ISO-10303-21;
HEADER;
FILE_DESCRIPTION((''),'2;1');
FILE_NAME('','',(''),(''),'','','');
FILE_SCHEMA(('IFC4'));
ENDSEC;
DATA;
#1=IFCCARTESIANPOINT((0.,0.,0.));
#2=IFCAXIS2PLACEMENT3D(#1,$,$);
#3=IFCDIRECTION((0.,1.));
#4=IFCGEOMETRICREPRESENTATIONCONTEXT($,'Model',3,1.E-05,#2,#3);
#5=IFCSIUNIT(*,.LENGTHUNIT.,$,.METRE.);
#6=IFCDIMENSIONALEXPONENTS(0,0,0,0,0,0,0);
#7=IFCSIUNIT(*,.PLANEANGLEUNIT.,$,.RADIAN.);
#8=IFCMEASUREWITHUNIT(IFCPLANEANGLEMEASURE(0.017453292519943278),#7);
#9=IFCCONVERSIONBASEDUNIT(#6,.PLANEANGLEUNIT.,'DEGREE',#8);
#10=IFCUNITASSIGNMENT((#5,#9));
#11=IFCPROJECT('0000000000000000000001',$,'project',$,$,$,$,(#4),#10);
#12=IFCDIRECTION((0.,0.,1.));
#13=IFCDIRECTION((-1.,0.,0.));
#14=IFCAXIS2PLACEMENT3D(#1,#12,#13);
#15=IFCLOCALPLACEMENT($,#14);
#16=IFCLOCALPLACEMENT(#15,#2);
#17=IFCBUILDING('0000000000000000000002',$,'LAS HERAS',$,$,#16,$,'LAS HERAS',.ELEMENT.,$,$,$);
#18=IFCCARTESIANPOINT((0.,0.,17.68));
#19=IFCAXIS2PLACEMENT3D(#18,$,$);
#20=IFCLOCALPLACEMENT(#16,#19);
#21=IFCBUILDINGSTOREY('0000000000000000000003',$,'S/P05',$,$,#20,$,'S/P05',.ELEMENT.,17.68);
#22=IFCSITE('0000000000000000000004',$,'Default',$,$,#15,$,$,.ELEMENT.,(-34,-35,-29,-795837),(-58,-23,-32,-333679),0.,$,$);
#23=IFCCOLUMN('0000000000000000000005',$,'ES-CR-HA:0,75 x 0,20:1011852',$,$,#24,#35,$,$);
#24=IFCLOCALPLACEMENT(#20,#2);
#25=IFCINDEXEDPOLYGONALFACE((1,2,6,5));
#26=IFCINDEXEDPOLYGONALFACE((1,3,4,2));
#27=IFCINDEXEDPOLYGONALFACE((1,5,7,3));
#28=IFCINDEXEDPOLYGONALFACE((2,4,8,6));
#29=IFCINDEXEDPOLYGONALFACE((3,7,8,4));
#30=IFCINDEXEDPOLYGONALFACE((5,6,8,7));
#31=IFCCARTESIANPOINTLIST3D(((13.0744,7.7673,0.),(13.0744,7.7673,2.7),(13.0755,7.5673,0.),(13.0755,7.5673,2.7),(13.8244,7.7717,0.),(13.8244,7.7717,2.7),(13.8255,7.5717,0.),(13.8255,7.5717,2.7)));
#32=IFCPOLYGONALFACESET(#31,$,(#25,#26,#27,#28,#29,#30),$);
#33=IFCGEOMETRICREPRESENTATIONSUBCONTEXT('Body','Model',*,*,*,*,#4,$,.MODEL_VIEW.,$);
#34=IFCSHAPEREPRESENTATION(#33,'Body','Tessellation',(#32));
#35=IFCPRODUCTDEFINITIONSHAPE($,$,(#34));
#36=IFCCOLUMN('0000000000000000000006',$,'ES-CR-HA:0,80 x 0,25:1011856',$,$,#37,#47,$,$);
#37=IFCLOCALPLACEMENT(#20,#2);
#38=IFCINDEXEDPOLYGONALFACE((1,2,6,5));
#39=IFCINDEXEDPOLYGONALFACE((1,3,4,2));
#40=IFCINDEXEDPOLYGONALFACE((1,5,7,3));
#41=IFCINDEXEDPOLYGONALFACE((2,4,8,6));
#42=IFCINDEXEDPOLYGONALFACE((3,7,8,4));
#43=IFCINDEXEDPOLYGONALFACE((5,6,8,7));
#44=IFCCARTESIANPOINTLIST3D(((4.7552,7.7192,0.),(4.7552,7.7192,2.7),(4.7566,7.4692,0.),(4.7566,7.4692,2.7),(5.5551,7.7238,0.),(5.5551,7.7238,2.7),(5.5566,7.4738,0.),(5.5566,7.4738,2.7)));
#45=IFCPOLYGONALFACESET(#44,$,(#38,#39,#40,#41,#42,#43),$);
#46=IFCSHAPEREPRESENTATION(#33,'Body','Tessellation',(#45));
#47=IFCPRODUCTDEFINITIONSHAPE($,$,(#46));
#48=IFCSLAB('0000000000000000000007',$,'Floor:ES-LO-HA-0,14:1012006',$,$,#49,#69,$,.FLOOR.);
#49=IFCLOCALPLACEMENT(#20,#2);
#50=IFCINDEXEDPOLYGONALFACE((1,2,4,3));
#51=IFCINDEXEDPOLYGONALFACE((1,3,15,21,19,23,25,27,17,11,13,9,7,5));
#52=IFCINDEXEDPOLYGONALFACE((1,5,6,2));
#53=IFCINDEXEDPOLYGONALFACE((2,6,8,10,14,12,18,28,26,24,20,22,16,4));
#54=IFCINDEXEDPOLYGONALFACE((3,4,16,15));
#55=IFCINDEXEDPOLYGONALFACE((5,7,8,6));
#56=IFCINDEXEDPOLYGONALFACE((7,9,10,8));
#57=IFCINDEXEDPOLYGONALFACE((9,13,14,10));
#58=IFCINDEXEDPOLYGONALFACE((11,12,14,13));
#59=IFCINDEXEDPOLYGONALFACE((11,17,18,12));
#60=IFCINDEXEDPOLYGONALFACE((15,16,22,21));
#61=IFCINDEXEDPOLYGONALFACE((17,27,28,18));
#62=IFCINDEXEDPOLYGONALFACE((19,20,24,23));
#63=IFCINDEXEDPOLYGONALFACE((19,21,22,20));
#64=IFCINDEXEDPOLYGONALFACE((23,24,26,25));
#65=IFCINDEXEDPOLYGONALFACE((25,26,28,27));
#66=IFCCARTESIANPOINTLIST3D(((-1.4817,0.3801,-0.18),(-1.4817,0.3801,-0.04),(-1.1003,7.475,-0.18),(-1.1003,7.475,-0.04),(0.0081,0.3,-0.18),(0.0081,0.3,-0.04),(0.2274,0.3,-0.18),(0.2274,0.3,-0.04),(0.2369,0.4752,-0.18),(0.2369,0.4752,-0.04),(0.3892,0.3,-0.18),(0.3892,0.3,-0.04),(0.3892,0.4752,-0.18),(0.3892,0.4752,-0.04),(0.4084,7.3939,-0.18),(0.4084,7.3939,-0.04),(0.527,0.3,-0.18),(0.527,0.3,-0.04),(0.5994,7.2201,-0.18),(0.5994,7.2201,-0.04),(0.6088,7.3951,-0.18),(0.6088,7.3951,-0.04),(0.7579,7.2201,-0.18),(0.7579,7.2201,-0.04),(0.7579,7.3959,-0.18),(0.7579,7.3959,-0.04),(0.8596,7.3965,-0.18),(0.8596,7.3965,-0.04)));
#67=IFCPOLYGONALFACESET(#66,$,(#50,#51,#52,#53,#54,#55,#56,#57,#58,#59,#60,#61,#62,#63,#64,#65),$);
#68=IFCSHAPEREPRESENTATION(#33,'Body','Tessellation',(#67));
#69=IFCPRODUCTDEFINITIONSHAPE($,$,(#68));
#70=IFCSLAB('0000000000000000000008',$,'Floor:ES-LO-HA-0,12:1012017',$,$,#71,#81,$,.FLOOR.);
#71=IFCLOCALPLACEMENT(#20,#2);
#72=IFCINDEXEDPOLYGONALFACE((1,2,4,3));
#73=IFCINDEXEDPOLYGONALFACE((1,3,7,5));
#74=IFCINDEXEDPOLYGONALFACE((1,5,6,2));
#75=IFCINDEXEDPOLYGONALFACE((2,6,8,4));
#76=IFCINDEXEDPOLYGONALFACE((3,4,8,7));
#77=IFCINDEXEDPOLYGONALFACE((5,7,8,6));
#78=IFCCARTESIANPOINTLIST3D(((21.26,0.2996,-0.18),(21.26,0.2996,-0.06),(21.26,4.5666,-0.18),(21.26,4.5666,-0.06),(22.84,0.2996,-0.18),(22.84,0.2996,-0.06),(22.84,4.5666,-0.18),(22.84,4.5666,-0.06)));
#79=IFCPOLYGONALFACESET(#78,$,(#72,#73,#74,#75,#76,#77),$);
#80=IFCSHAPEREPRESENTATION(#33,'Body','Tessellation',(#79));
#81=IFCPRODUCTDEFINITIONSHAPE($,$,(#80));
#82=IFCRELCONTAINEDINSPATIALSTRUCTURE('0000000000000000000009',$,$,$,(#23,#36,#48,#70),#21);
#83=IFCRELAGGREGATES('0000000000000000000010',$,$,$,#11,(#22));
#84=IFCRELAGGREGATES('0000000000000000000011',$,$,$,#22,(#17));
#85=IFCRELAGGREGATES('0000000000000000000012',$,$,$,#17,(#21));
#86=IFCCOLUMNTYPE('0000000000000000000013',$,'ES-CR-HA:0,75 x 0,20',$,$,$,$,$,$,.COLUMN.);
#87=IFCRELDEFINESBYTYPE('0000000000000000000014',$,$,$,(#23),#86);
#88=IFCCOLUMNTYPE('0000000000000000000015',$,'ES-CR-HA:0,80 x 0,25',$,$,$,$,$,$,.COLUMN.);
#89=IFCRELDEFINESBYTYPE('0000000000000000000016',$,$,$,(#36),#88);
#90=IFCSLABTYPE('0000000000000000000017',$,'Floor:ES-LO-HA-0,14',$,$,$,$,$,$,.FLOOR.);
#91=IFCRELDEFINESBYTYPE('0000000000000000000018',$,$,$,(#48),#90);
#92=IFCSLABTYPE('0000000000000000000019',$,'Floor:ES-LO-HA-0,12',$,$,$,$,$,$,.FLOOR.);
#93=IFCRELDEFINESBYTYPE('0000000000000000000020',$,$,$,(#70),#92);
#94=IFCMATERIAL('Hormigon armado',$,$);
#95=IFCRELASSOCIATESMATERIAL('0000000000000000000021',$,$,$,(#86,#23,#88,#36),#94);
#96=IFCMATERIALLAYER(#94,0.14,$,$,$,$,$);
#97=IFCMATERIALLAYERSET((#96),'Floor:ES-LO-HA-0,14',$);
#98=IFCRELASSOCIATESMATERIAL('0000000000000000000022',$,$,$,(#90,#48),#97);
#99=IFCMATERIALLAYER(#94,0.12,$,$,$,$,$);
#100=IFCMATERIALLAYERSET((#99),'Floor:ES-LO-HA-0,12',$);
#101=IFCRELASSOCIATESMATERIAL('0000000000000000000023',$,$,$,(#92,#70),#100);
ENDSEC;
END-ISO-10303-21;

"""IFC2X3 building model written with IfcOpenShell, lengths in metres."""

from ifc_helpers import new_model, entity, si_unit, converted_unit, direction, frame, frame_2d, origin, place, context, subcontext, project, spatial, polyline, rectangle, outline, extrude, source, transform, mapped, material, layer, layer_set, layer_usage, type_object, type_shapes, element, save


model = new_model("IFC2X3")

# Units and contexts
model_context = context("Model", 3, precision=1e-05, world=origin(), true_north=direction((0.0, 1.0)))
body_context = subcontext(model_context, "Body", "Model", "MODEL_VIEW")
ifc_project = project(units=[si_unit("LENGTHUNIT", "METRE"), converted_unit("PLANEANGLEUNIT", "DEGREE", entity("IfcPlaneAngleMeasure", 0.017453292519943278), si_unit("PLANEANGLEUNIT", "RADIAN"), dimensions=[0, 0, 0, 0, 0, 0, 0])], contexts=[model_context])

# Site, building, storey
site_placement = place(None, frame((0.0, 0.0, 0.0), z_axis=(0.0, 0.0, 1.0), x_axis=(-1.0, 0.0, 0.0)))
site = spatial("IfcSite", under=ifc_project, at=site_placement, Name="Default", CompositionType="ELEMENT", RefLatitude=(-34, -35, -29, -795837), RefLongitude=(-58, -23, -32, -333679), RefElevation=0.0)
building_placement = place(site_placement, origin())
building = spatial("IfcBuilding", under=site, at=building_placement, Name="LAS HERAS", LongName="LAS HERAS", CompositionType="ELEMENT")
storey_placement = place(building_placement, frame((0.0, 0.0, 17.68)))
storey = spatial("IfcBuildingStorey", under=building, at=storey_placement, Name="S/P05", LongName="S/P05", CompositionType="ELEMENT", Elevation=17.68)

# Columns
ifc_material = material(Name="Hormigon armado")
column_type_1 = type_object("IfcColumnType", Name="ES-CR-HA:0,75 x 0,20", PredefinedType="COLUMN", material=ifc_material)
shared_shape_1 = source(origin(), body_context, "Body", "SweptSolid", [
    extrude(rectangle(XDim=0.75, YDim=0.2, at=frame_2d((0.0, 0.0), x_axis=(1.0, 0.0))), frame((13.4499, 7.6695, 17.68), z_axis=(0.0, 0.0, 1.0), x_axis=(-0.999983, -0.005788, 0.0)), (0.0, 0.0, 1.0), 2.7),
])
type_shapes(column_type_1, [shared_shape_1])
column_1_placement = place(storey_placement, frame((0.0, 0.0, -17.68)))
element("IfcColumn", 1, at=column_1_placement, inside=storey, type_object=column_type_1, material=ifc_material, Name="ES-CR-HA:0,75 x 0,20:1011852", context=body_context, shape_type="MappedRepresentation", body=[
    mapped(shared_shape_1, transform((0.0, 0.0, 0.0), scale=1.0)),
])
column_type_2 = type_object("IfcColumnType", Name="ES-CR-HA:0,80 x 0,25", PredefinedType="COLUMN", material=ifc_material)
shared_shape_2 = source(origin(), body_context, "Body", "SweptSolid", [
    extrude(rectangle(XDim=0.8, YDim=0.25, at=frame_2d((0.0, 0.0), x_axis=(1.0, 0.0))), frame((5.1559, 7.5965, 17.68), z_axis=(0.0, 0.0, 1.0), x_axis=(-0.999983, -0.005788, 0.0)), (0.0, 0.0, 1.0), 2.7),
])
type_shapes(column_type_2, [shared_shape_2])
column_2_placement = place(storey_placement, frame((0.0, 0.0, -17.68)))
element("IfcColumn", 2, at=column_2_placement, inside=storey, type_object=column_type_2, material=ifc_material, Name="ES-CR-HA:0,80 x 0,25:1011856", context=body_context, shape_type="MappedRepresentation", body=[
    mapped(shared_shape_2, transform((0.0, 0.0, 0.0), scale=1.0)),
])

# Slab, openings
ifc_layer_1 = layer(ifc_material, 0.14)
ifc_layer_set_1 = layer_set([ifc_layer_1], Name="Floor:ES-LO-HA-0,14")
ifc_layer_usage_1 = layer_usage(ifc_layer_set_1, "AXIS3", "POSITIVE", 0.0)
slab_type_1 = type_object("IfcSlabType", Name="Floor:ES-LO-HA-0,14", PredefinedType="FLOOR", material=ifc_layer_set_1)
slab_1_placement = place(storey_placement, origin())
slab_1 = element("IfcSlab", 3, at=slab_1_placement, inside=storey, type_object=slab_type_1, material=ifc_layer_usage_1, Name="Floor:ES-LO-HA-0,14:1012006", PredefinedType="FLOOR", context=body_context, shape_type="SweptSolid", body=[
    extrude(outline(polyline([(-0.2993, -3.5591), (-0.1615, -3.5591), (-0.1615, -3.3839), (-0.0091, -3.3839), (0.0003, -3.5591), (0.2196, -3.5591), (1.7094, -3.479), (1.328, 3.6159), (-0.1807, 3.5348), (-0.3811, 3.536), (-0.3717, 3.3611), (-0.5302, 3.3611), (-0.5302, 3.5368), (-0.6319, 3.5374), (-0.2993, -3.5591)])), frame((0.2277, 3.8591, -0.04), z_axis=(0.0, 0.0, -1.0), x_axis=(-1.0, 0.0, 0.0)), (0.0, 0.0, 1.0), 0.14),
])
opening_1_placement = place(slab_1_placement, origin())
element("IfcOpeningElement", 4, at=opening_1_placement, cuts=slab_1, ObjectType="Opening", context=body_context, shape_type="SweptSolid", body=[
    extrude(outline(polyline([(0.2369, 0.4752), (0.2274, 0.3), (0.3892, 0.3), (0.3892, 0.4752), (0.2369, 0.4752)])), frame((0.0, 0.0, -0.04)), (0.0, 0.0, -1.0), 0.14),
])
opening_2_placement = place(slab_1_placement, origin())
element("IfcOpeningElement", 5, at=opening_2_placement, cuts=slab_1, ObjectType="Opening", context=body_context, shape_type="SweptSolid", body=[
    extrude(outline(polyline([(0.7579, 7.2201), (0.7579, 7.3959), (0.6088, 7.3951), (0.5994, 7.2201), (0.7579, 7.2201)])), frame((0.0, 0.0, -0.04)), (0.0, 0.0, -1.0), 0.14),
])

# Slab
ifc_layer_2 = layer(ifc_material, 0.12)
ifc_layer_set_2 = layer_set([ifc_layer_2], Name="Floor:ES-LO-HA-0,12")
ifc_layer_usage_2 = layer_usage(ifc_layer_set_2, "AXIS3", "POSITIVE", 0.0)
slab_type_2 = type_object("IfcSlabType", Name="Floor:ES-LO-HA-0,12", PredefinedType="FLOOR", material=ifc_layer_set_2)
slab_2_placement = place(storey_placement, origin())
element("IfcSlab", 6, at=slab_2_placement, inside=storey, type_object=slab_type_2, material=ifc_layer_usage_2, Name="Floor:ES-LO-HA-0,12:1012017", PredefinedType="FLOOR", context=body_context, shape_type="SweptSolid", body=[
    extrude(rectangle(XDim=4.2671, YDim=1.58, at=frame_2d((0.0, 0.0), x_axis=(1.0, 0.0))), frame((22.05, 2.4331, -0.06), z_axis=(0.0, 0.0, -1.0), x_axis=(0.0, 1.0, 0.0)), (0.0, 0.0, 1.0), 0.12),
])

save(model, "model.ifc")
